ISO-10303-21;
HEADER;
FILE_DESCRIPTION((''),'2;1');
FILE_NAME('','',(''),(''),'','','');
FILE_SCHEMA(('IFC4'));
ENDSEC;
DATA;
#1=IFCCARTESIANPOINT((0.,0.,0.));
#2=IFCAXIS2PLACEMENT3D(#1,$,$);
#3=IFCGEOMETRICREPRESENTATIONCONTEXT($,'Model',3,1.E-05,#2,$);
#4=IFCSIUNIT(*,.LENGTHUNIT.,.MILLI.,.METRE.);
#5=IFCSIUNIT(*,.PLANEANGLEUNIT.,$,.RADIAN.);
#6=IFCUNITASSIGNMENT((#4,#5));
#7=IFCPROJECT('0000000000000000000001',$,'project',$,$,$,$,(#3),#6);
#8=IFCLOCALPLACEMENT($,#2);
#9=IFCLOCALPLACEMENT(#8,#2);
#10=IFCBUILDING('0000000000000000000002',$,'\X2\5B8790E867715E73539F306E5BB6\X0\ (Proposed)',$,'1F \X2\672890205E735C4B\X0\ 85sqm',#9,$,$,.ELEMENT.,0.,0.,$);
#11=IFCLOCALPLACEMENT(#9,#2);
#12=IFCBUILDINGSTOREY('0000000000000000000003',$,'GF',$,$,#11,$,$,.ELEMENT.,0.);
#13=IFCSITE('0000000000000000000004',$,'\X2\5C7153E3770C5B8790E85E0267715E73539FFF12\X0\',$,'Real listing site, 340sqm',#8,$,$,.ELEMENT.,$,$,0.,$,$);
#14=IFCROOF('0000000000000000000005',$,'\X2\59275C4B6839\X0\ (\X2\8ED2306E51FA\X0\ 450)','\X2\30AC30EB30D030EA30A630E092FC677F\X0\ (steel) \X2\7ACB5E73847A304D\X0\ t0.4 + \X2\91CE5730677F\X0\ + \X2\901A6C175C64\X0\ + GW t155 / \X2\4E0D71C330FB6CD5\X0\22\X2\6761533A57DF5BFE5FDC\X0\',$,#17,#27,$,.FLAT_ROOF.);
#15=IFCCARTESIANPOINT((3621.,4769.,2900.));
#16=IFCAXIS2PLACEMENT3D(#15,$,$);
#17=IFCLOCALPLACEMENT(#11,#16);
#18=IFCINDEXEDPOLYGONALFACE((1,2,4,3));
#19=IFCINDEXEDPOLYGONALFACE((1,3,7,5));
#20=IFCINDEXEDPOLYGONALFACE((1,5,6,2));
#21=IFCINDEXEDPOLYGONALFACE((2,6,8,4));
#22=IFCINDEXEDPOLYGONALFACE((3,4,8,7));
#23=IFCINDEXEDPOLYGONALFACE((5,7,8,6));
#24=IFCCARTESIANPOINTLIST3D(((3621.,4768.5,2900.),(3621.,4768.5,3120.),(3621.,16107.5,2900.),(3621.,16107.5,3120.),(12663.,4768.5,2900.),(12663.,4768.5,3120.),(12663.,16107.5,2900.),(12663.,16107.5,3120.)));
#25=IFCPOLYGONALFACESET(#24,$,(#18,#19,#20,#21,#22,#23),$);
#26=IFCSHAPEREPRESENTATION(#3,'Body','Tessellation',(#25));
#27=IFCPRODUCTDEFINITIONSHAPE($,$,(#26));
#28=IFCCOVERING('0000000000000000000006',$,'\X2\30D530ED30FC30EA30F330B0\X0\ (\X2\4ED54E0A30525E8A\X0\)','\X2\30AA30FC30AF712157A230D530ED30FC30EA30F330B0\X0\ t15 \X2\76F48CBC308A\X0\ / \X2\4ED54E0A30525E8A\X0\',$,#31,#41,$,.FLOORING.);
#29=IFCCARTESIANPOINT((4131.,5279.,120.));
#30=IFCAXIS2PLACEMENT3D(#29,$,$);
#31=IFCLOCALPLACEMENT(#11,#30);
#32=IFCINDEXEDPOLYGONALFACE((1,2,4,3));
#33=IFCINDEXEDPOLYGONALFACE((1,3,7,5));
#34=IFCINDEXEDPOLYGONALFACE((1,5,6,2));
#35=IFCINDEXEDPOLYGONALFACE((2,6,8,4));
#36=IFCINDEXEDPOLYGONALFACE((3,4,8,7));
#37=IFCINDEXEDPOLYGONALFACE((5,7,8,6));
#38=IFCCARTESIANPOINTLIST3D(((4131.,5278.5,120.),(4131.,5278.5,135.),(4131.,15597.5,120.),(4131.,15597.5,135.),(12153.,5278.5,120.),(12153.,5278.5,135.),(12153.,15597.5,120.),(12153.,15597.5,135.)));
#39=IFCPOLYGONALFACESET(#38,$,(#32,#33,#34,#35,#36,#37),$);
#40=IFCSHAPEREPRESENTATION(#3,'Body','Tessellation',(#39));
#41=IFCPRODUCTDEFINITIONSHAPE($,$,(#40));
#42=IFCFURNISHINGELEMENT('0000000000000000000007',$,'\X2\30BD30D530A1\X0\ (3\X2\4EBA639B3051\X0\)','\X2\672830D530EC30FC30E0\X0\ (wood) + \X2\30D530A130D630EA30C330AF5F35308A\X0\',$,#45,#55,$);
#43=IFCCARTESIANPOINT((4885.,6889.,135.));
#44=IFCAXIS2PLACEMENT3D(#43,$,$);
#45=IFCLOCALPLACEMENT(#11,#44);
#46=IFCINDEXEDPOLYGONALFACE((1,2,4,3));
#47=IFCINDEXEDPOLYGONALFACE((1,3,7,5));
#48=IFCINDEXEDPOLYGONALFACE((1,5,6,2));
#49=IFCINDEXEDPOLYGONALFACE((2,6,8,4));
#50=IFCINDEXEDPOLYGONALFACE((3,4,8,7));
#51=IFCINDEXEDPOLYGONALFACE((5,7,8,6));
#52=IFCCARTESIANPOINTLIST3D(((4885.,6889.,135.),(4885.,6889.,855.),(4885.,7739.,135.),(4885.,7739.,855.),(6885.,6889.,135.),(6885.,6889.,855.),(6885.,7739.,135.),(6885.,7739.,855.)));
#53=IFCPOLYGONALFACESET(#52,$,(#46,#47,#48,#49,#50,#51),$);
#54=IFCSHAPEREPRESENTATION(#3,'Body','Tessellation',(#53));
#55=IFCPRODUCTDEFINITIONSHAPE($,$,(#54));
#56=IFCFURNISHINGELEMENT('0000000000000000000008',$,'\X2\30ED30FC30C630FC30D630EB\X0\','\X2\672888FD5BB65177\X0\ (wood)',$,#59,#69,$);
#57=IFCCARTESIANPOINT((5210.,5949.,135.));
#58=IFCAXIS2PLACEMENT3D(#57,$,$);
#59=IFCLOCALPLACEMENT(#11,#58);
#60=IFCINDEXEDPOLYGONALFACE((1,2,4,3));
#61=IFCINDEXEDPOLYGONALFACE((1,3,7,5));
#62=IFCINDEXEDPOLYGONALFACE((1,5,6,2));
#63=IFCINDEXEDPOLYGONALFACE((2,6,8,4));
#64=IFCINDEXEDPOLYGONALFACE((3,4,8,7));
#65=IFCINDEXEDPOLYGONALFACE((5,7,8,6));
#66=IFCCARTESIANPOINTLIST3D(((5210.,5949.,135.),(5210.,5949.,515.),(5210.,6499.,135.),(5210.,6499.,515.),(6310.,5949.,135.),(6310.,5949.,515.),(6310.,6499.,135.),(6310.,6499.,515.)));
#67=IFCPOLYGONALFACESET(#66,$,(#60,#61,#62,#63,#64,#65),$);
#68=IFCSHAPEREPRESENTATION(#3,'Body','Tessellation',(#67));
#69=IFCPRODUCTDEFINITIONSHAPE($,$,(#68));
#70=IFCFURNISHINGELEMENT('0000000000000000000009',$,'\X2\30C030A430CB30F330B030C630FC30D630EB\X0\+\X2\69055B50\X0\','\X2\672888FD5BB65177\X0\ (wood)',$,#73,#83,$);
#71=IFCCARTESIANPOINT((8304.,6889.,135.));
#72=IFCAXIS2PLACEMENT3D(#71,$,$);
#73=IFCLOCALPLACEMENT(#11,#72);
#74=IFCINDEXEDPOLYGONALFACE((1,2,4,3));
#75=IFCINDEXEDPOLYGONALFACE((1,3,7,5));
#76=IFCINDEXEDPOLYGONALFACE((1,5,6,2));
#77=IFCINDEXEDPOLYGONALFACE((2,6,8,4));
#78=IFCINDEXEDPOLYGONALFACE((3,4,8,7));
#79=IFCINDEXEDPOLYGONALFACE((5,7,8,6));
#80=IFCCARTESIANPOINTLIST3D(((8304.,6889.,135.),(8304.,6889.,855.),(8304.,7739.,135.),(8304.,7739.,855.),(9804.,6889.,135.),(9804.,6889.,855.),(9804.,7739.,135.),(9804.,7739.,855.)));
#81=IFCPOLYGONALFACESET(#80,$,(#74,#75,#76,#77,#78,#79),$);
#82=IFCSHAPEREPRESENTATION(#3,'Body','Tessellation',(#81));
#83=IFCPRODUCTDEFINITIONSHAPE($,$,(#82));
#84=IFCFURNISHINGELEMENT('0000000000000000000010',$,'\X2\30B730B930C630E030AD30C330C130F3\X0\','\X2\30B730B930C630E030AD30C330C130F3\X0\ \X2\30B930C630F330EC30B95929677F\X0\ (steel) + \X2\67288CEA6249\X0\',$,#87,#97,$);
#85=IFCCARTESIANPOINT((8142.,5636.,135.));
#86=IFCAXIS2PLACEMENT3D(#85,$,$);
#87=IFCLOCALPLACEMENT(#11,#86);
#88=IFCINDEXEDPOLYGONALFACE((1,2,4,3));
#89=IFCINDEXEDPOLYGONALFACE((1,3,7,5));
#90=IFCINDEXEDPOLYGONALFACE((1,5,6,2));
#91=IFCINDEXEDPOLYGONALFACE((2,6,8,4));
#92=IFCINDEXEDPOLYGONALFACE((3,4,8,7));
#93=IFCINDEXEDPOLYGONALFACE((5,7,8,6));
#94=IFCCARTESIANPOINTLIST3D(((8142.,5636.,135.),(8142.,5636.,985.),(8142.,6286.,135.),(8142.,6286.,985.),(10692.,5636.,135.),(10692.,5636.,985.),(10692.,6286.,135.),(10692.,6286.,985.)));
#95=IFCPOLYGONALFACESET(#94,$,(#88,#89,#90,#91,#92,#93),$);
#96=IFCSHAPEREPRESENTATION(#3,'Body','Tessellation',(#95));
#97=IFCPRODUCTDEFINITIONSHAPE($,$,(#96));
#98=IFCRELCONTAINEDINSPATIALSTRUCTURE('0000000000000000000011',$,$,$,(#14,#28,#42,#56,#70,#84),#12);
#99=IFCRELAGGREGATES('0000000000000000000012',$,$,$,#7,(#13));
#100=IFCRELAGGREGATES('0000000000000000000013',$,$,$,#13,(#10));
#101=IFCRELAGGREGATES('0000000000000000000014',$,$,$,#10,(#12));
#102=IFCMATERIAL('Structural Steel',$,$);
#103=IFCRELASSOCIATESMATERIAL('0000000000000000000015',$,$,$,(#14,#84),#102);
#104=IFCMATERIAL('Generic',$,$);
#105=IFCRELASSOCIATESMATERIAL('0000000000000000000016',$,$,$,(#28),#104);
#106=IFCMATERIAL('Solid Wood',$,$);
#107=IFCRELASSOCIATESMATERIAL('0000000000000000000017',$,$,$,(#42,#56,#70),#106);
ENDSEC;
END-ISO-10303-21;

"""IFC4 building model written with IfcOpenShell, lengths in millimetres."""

from ifc_helpers import new_model, si_unit, frame, frame_2d, origin, place, context, project, spatial, rectangle, extrude, material, element, save


model = new_model("IFC4")

# Units and contexts
model_context = context("Model", 3, precision=1e-05, world=origin())
ifc_project = project(units=[si_unit("LENGTHUNIT", "METRE", prefix="MILLI"), si_unit("PLANEANGLEUNIT", "RADIAN")], contexts=[model_context])

# Site, building, storey
site_placement = place(None, origin())
site = spatial("IfcSite", under=ifc_project, at=site_placement, Name="山口県宇部市東平原２", ObjectType="Real listing site, 340sqm", CompositionType="ELEMENT", RefElevation=0.0)
building_placement = place(site_placement, origin())
building = spatial("IfcBuilding", under=site, at=building_placement, Name="宇部東平原の家 (Proposed)", ObjectType="1F 木造平屋 85sqm", CompositionType="ELEMENT", ElevationOfRefHeight=0.0, ElevationOfTerrain=0.0)
storey_placement = place(building_placement, origin())
storey = spatial("IfcBuildingStorey", under=building, at=storey_placement, Name="GF", CompositionType="ELEMENT", Elevation=0.0)

# Shared definitions
ifc_material_1 = material(Name="Solid Wood")

# Roof
ifc_material_2 = material(Name="Structural Steel")
roof_placement = place(storey_placement, frame((3621.0, 4769.0, 2900.0)))
element("IfcRoof", 1, at=roof_placement, inside=storey, material=ifc_material_2, Name="大屋根 (軒の出 450)", Description="ガルバリウム鋼板 (steel) 立平葺き t0.4 + 野地板 + 通気層 + GW t155 / 不燃・法22条区域対応", PredefinedType="FLAT_ROOF", context=model_context, shape_type="SweptSolid", body=[
    extrude(rectangle(XDim=9042.0, YDim=11339.0, at=frame_2d((4521.0, 5669.0))), frame((3621.0, 4769.0, 2900.0)), (0.0, 0.0, 1.0), 220.0),
])

# Covering
ifc_material_3 = material(Name="Generic")
covering_placement = place(storey_placement, frame((4131.0, 5279.0, 120.0)))
element("IfcCovering", 2, at=covering_placement, inside=storey, material=ifc_material_3, Name="フローリング (仕上げ床)", Description="オーク無垢フローリング t15 直貼り / 仕上げ床", PredefinedType="FLOORING", context=model_context, shape_type="SweptSolid", body=[
    extrude(rectangle(XDim=8022.0, YDim=10319.0, at=frame_2d((4011.0, 5159.0))), frame((4131.0, 5279.0, 120.0)), (0.0, 0.0, 1.0), 15.0),
])

# Furnishing elements
furnishing_1_placement = place(storey_placement, frame((4885.0, 6889.0, 135.0)))
element("IfcFurnishingElement", 3, at=furnishing_1_placement, inside=storey, material=ifc_material_1, Name="ソファ (3人掛け)", Description="木フレーム (wood) + ファブリック張り", context=model_context, shape_type="SweptSolid", body=[
    extrude(rectangle(XDim=2000.0, YDim=850.0, at=frame_2d((1000.0, 425.0))), frame((4885.0, 6889.0, 135.0)), (0.0, 0.0, 1.0), 720.0),
])
furnishing_2_placement = place(storey_placement, frame((5210.0, 5949.0, 135.0)))
element("IfcFurnishingElement", 4, at=furnishing_2_placement, inside=storey, material=ifc_material_1, Name="ローテーブル", Description="木製家具 (wood)", context=model_context, shape_type="SweptSolid", body=[
    extrude(rectangle(XDim=1100.0, YDim=550.0, at=frame_2d((550.0, 275.0))), frame((5210.0, 5949.0, 135.0)), (0.0, 0.0, 1.0), 380.0),
])
furnishing_3_placement = place(storey_placement, frame((8304.0, 6889.0, 135.0)))
element("IfcFurnishingElement", 5, at=furnishing_3_placement, inside=storey, material=ifc_material_1, Name="ダイニングテーブル+椅子", Description="木製家具 (wood)", context=model_context, shape_type="SweptSolid", body=[
    extrude(rectangle(XDim=1500.0, YDim=850.0, at=frame_2d((750.0, 425.0))), frame((8304.0, 6889.0, 135.0)), (0.0, 0.0, 1.0), 720.0),
])
furnishing_4_placement = place(storey_placement, frame((8142.0, 5636.0, 135.0)))
element("IfcFurnishingElement", 6, at=furnishing_4_placement, inside=storey, material=ifc_material_2, Name="システムキッチン", Description="システムキッチン ステンレス天板 (steel) + 木質扉", context=model_context, shape_type="SweptSolid", body=[
    extrude(rectangle(XDim=2550.0, YDim=650.0, at=frame_2d((1275.0, 325.0))), frame((8142.0, 5636.0, 135.0)), (0.0, 0.0, 1.0), 850.0),
])

save(model, "model.ifc")
